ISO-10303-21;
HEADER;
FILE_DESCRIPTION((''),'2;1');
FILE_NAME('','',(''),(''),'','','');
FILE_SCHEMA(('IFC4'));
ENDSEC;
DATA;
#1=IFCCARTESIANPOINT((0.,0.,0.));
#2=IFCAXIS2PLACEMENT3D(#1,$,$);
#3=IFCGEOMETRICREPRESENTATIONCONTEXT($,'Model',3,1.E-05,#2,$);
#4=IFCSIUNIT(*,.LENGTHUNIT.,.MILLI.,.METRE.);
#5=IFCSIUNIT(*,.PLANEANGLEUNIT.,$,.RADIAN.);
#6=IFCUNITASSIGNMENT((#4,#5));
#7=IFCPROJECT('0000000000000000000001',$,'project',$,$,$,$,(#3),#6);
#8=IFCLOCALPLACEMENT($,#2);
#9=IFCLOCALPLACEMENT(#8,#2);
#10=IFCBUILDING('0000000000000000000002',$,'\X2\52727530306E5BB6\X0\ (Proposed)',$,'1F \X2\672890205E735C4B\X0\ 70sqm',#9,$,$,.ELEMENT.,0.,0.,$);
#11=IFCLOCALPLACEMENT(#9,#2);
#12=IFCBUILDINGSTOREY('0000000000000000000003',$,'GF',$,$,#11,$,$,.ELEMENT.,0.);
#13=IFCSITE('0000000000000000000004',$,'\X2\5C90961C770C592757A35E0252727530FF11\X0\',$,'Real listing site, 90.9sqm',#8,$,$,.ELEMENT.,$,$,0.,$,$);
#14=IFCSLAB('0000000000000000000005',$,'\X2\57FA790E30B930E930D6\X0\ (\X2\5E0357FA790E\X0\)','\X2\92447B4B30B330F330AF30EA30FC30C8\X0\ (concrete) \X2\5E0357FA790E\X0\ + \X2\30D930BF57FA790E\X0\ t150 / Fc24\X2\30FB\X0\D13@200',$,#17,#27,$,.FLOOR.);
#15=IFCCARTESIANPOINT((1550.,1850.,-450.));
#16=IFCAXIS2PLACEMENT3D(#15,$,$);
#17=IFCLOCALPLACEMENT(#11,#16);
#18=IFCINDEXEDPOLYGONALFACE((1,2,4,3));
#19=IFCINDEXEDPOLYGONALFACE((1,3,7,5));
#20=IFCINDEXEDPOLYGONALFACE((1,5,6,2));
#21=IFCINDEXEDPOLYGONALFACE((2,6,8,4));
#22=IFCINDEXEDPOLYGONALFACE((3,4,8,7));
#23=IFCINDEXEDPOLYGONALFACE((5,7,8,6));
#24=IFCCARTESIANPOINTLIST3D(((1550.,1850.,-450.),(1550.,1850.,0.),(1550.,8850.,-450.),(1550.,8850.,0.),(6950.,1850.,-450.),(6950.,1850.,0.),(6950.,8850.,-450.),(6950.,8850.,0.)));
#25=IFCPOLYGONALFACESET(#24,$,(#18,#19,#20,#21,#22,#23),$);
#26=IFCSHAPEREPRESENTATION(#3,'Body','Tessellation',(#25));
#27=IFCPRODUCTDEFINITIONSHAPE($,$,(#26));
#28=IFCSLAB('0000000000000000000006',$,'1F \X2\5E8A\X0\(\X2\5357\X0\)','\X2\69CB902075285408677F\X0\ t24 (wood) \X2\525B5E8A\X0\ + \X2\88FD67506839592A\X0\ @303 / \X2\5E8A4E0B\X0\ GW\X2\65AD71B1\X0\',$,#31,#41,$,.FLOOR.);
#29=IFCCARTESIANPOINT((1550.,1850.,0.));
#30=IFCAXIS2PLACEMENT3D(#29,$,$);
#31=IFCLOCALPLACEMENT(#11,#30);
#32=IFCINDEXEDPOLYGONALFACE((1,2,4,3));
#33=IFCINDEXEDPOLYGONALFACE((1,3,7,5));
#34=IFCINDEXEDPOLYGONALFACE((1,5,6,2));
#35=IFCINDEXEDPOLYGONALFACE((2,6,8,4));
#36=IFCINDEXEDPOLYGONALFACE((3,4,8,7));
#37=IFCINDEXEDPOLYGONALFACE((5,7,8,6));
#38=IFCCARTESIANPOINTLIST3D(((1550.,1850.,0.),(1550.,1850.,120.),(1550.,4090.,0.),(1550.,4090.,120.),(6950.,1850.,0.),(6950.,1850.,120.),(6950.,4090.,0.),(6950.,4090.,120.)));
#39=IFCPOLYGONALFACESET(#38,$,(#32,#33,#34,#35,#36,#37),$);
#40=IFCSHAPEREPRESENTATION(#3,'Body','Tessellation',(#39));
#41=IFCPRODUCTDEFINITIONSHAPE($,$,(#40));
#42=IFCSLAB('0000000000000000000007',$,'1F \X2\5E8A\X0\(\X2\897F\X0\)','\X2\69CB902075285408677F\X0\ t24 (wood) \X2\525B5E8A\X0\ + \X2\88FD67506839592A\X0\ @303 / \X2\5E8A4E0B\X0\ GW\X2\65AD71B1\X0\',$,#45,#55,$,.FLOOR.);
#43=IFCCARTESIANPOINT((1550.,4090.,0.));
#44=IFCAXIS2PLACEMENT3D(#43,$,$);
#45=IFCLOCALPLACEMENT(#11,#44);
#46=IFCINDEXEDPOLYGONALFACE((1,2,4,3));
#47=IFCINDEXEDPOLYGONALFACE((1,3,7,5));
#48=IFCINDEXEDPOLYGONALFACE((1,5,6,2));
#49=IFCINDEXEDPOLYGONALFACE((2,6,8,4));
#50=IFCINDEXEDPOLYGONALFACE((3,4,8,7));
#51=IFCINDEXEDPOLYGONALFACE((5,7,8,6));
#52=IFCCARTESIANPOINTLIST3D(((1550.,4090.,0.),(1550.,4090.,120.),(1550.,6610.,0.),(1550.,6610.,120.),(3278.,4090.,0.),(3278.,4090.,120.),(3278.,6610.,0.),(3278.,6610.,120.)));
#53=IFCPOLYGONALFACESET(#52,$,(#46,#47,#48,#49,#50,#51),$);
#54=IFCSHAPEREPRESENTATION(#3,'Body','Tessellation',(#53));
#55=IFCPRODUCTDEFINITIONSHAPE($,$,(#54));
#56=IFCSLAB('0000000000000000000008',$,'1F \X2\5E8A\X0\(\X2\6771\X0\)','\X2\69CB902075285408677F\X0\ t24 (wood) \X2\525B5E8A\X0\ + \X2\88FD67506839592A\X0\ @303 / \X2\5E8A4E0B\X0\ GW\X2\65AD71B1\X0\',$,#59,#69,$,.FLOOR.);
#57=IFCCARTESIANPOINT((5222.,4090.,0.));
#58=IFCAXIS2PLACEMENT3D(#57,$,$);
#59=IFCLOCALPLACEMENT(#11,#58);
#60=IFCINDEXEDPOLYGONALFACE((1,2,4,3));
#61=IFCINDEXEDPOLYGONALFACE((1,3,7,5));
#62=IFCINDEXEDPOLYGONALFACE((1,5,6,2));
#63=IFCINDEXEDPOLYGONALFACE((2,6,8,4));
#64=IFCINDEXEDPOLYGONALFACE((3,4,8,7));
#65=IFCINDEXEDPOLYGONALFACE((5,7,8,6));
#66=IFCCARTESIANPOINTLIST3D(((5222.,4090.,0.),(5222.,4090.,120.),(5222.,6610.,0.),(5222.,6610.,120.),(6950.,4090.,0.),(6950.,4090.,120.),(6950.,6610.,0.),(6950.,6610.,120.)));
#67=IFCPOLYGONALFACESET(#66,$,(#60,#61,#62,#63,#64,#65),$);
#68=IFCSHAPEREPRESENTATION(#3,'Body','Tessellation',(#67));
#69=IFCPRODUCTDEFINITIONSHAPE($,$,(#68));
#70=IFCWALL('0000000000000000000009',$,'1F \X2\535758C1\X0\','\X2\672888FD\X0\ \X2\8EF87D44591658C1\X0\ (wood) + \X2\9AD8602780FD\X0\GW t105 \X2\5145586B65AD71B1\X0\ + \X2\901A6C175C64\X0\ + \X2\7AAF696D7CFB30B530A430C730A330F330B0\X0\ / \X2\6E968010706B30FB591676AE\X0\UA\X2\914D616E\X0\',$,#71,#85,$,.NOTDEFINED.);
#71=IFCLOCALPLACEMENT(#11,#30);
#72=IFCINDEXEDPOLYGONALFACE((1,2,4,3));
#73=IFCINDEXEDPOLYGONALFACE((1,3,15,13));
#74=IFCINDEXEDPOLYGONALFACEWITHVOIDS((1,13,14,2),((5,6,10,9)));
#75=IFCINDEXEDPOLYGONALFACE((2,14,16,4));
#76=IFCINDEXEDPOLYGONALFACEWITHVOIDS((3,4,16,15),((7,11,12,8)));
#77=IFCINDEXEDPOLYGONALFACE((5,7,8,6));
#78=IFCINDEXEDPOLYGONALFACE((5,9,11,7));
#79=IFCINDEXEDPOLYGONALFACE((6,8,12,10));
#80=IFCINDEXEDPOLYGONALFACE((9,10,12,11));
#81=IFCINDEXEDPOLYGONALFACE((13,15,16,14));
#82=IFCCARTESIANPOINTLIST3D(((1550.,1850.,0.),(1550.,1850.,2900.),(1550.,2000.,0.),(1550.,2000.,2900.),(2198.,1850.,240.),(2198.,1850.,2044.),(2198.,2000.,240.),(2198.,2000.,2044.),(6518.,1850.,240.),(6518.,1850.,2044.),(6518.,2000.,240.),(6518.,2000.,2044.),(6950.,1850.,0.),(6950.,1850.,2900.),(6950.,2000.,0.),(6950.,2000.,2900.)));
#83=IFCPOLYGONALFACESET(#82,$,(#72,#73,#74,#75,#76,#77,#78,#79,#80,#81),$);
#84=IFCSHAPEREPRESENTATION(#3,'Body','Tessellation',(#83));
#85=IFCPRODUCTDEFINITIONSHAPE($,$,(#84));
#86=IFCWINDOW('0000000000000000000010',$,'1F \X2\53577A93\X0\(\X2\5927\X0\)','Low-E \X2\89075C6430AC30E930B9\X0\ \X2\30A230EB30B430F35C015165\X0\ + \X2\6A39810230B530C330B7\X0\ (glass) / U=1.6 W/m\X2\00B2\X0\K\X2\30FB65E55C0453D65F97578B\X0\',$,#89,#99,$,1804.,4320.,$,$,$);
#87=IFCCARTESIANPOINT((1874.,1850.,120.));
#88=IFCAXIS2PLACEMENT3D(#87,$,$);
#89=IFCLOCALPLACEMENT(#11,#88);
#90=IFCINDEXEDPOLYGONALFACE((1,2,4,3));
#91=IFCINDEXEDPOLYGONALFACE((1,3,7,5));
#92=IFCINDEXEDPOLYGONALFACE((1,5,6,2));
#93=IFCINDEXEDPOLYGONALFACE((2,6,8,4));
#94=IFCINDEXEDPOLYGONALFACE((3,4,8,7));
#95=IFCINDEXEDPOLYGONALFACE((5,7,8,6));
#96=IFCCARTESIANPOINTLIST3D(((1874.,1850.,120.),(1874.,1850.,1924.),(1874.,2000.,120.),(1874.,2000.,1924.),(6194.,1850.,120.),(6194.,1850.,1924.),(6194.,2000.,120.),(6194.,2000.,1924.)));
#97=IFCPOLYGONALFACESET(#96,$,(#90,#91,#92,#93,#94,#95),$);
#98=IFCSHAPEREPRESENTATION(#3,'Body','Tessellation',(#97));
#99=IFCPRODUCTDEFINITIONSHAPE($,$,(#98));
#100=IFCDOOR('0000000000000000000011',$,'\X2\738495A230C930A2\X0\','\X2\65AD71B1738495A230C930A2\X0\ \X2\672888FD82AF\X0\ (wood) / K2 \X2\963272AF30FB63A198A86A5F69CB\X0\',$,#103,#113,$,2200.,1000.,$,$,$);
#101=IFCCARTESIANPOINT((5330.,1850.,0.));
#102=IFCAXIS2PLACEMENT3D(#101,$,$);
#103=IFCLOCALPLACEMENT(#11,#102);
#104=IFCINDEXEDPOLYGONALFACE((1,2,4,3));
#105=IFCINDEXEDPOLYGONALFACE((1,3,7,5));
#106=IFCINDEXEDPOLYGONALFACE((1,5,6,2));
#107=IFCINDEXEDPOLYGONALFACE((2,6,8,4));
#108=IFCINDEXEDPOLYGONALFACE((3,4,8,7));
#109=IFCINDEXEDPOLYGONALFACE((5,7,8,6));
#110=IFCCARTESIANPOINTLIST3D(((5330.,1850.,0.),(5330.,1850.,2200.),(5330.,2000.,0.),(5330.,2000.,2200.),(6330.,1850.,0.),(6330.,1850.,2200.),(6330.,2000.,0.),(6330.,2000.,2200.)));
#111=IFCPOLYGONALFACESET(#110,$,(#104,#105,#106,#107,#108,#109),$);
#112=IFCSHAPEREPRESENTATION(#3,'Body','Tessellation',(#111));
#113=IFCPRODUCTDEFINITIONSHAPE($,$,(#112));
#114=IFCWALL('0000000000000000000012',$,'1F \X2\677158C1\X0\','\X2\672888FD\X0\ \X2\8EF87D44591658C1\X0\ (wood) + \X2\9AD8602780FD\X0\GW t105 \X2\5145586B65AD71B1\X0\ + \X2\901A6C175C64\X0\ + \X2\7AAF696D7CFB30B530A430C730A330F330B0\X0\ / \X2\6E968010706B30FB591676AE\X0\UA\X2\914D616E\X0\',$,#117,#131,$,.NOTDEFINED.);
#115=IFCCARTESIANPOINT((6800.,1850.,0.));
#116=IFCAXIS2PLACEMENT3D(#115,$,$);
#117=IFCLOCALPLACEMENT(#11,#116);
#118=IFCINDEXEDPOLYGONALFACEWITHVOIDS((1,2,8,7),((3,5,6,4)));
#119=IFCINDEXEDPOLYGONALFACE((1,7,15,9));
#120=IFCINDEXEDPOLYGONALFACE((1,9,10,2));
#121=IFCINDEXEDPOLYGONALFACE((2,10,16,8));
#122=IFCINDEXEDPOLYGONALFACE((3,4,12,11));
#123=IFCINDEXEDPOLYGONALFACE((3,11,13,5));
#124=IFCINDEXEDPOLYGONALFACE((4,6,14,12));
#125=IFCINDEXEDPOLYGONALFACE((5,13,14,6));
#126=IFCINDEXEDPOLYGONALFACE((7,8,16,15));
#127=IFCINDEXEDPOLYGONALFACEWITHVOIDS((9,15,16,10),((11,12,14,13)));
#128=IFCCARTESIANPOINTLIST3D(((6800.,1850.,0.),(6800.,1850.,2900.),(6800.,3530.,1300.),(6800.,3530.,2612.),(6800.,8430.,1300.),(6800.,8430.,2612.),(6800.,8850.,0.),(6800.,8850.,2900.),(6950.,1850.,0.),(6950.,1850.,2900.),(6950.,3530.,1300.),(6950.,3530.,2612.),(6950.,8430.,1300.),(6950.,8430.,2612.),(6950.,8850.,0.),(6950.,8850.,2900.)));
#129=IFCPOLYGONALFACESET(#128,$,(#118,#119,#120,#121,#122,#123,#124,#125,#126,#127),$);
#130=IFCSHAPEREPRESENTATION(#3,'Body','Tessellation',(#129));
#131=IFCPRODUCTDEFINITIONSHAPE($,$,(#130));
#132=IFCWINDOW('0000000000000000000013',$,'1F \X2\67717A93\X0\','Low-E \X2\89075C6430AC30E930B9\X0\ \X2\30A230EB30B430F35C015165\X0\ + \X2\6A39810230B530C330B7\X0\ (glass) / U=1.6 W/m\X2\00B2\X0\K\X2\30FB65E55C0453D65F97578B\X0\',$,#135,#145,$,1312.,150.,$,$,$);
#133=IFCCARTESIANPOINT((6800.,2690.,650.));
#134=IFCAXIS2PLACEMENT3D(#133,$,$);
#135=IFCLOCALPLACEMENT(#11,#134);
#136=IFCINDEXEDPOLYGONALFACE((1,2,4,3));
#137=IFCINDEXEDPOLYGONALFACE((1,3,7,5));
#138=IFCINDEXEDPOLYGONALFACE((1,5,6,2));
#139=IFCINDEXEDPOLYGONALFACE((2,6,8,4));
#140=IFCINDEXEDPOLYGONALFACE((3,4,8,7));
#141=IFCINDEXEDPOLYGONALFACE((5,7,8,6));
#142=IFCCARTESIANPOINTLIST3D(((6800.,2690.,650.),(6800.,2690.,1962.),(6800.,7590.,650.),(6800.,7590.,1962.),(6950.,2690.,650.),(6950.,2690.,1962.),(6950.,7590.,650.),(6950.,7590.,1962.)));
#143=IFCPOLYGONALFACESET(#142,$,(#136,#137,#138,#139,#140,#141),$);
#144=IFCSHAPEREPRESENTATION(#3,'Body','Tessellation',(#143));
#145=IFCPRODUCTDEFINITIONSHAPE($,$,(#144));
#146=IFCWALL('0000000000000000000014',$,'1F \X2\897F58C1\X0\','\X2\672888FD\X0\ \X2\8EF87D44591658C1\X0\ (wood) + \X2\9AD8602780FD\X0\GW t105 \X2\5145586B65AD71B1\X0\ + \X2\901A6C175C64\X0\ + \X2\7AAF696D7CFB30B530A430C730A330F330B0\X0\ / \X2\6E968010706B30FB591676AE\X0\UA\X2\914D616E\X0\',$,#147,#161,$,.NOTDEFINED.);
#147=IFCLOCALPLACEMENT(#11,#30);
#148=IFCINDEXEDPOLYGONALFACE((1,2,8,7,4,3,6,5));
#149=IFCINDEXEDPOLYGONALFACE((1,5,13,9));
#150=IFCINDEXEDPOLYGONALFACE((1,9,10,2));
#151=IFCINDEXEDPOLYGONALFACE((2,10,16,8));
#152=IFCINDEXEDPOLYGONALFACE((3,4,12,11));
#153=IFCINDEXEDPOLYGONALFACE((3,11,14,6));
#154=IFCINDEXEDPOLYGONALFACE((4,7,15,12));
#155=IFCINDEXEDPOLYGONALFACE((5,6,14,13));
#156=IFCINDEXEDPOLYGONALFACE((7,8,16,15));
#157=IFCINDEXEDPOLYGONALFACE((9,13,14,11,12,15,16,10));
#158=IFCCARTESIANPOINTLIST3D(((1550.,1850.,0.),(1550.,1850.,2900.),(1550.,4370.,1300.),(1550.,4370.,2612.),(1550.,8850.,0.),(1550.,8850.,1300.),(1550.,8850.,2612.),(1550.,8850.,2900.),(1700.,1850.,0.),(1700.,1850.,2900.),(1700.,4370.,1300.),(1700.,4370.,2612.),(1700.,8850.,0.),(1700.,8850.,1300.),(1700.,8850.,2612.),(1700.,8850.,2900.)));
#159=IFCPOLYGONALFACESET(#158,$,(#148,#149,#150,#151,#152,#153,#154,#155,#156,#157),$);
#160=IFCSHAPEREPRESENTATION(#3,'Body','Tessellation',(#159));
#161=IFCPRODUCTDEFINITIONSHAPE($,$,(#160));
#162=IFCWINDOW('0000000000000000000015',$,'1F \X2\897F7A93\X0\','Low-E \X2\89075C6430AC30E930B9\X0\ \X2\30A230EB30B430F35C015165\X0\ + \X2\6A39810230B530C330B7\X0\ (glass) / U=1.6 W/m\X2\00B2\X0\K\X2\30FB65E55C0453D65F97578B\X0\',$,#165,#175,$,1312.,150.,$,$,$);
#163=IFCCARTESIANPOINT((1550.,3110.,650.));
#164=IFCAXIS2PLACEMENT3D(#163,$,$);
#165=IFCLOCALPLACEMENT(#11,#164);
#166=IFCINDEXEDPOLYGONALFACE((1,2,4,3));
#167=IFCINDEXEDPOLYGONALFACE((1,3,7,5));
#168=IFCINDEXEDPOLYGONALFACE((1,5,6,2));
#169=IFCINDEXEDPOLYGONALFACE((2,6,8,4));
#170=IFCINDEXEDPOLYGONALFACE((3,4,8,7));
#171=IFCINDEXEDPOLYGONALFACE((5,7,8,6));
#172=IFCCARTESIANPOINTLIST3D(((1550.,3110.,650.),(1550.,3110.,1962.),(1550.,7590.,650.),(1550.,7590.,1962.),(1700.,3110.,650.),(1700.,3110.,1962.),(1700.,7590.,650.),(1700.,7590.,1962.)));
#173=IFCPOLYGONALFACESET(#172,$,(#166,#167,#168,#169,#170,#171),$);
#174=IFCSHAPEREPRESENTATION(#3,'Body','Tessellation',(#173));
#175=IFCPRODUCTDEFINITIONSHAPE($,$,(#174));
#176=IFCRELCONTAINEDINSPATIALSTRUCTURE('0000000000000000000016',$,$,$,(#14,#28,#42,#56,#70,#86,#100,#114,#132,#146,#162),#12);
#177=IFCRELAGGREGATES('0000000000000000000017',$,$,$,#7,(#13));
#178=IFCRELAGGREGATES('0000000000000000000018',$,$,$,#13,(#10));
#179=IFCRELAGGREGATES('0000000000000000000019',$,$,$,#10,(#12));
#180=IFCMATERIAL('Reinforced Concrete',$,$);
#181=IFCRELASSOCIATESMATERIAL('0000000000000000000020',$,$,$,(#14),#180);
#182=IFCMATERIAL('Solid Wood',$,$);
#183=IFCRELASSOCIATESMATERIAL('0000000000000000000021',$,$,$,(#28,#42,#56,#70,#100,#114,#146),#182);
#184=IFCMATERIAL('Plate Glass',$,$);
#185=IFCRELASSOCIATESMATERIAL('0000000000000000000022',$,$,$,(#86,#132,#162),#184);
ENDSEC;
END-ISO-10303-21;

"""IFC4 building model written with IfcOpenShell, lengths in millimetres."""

from ifc_helpers import new_model, si_unit, frame, frame_2d, origin, place, context, project, spatial, rectangle, extrude, material, element, fill, save


model = new_model("IFC4")

# Units and contexts
model_context = context("Model", 3, precision=1e-05, world=origin())
ifc_project = project(units=[si_unit("LENGTHUNIT", "METRE", prefix="MILLI"), si_unit("PLANEANGLEUNIT", "RADIAN")], contexts=[model_context])

# Site, building, storey
site_placement = place(None, origin())
site = spatial("IfcSite", under=ifc_project, at=site_placement, Name="岐阜県大垣市割田１", ObjectType="Real listing site, 90.9sqm", CompositionType="ELEMENT", RefElevation=0.0)
building_placement = place(site_placement, origin())
building = spatial("IfcBuilding", under=site, at=building_placement, Name="割田の家 (Proposed)", ObjectType="1F 木造平屋 70sqm", CompositionType="ELEMENT", ElevationOfRefHeight=0.0, ElevationOfTerrain=0.0)
storey_placement = place(building_placement, origin())
storey = spatial("IfcBuildingStorey", under=building, at=storey_placement, Name="GF", CompositionType="ELEMENT", Elevation=0.0)

# Slabs
ifc_material_1 = material(Name="Reinforced Concrete")
slab_1_placement = place(storey_placement, frame((1550.0, 1850.0, -450.0)))
element("IfcSlab", 1, at=slab_1_placement, inside=storey, material=ifc_material_1, Name="基礎スラブ (布基礎)", Description="鉄筋コンクリート (concrete) 布基礎 + ベタ基礎 t150 / Fc24・D13@200", PredefinedType="FLOOR", context=model_context, shape_type="SweptSolid", body=[
    extrude(rectangle(XDim=5400.0, YDim=7000.0, at=frame_2d((2700.0, 3500.0))), frame((1550.0, 1850.0, -450.0)), (0.0, 0.0, 1.0), 450.0),
])
ifc_material_2 = material(Name="Solid Wood")
slab_2_placement = place(storey_placement, frame((1550.0, 1850.0, 0.0)))
element("IfcSlab", 2, at=slab_2_placement, inside=storey, material=ifc_material_2, Name="1F 床(南)", Description="構造用合板 t24 (wood) 剛床 + 製材根太 @303 / 床下 GW断熱", PredefinedType="FLOOR", context=model_context, shape_type="SweptSolid", body=[
    extrude(rectangle(XDim=5400.0, YDim=2240.0, at=frame_2d((2700.0, 1120.0))), frame((1550.0, 1850.0, 0.0)), (0.0, 0.0, 1.0), 120.0),
])
slab_3_placement = place(storey_placement, frame((1550.0, 4090.0, 0.0)))
element("IfcSlab", 3, at=slab_3_placement, inside=storey, material=ifc_material_2, Name="1F 床(西)", Description="構造用合板 t24 (wood) 剛床 + 製材根太 @303 / 床下 GW断熱", PredefinedType="FLOOR", context=model_context, shape_type="SweptSolid", body=[
    extrude(rectangle(XDim=1728.0, YDim=2520.0, at=frame_2d((864.0, 1260.0))), frame((1550.0, 4090.0, 0.0)), (0.0, 0.0, 1.0), 120.0),
])
slab_4_placement = place(storey_placement, frame((5222.0, 4090.0, 0.0)))
element("IfcSlab", 4, at=slab_4_placement, inside=storey, material=ifc_material_2, Name="1F 床(東)", Description="構造用合板 t24 (wood) 剛床 + 製材根太 @303 / 床下 GW断熱", PredefinedType="FLOOR", context=model_context, shape_type="SweptSolid", body=[
    extrude(rectangle(XDim=1728.0, YDim=2520.0, at=frame_2d((864.0, 1260.0))), frame((5222.0, 4090.0, 0.0)), (0.0, 0.0, 1.0), 120.0),
])

# Wall, openings, window, door
wall_1_placement = place(storey_placement, frame((1550.0, 1850.0, 0.0)))
wall_1 = element("IfcWall", 5, at=wall_1_placement, inside=storey, material=ifc_material_2, Name="1F 南壁", Description="木製 軸組外壁 (wood) + 高性能GW t105 充填断熱 + 通気層 + 窯業系サイディング / 準耐火・外皮UA配慮", PredefinedType="NOTDEFINED", context=model_context, shape_type="SweptSolid", body=[
    extrude(rectangle(XDim=5400.0, YDim=150.0, at=frame_2d((2700.0, 75.0))), frame((1550.0, 1850.0, 0.0)), (0.0, 0.0, 1.0), 2900.0),
])
opening_1_placement = place(storey_placement, frame((1874.0, 1850.0, 120.0)))
opening_1 = element("IfcOpeningElement", 6, at=opening_1_placement, cuts=wall_1, PredefinedType="NOTDEFINED", context=model_context, shape_type="SweptSolid", body=[
    extrude(rectangle(XDim=4320.0, YDim=150.0, at=frame_2d((2160.0, 75.0))), frame((1874.0, 1850.0, 120.0)), (0.0, 0.0, 1.0), 1804.0),
])
opening_2_placement = place(storey_placement, frame((5330.0, 1850.0, 0.0)))
opening_2 = element("IfcOpeningElement", 7, at=opening_2_placement, cuts=wall_1, PredefinedType="NOTDEFINED", context=model_context, shape_type="SweptSolid", body=[
    extrude(rectangle(XDim=1000.0, YDim=150.0, at=frame_2d((500.0, 75.0))), frame((5330.0, 1850.0, 0.0)), (0.0, 0.0, 1.0), 2200.0),
])
ifc_material_3 = material(Name="Plate Glass")
window_1_placement = place(storey_placement, frame((1874.0, 1850.0, 120.0)))
window_1 = element("IfcWindow", 8, at=window_1_placement, inside=storey, material=ifc_material_3, Name="1F 南窓(大)", Description="Low-E 複層ガラス アルゴン封入 + 樹脂サッシ (glass) / U=1.6 W/m²K・日射取得型", OverallHeight=1804.0, OverallWidth=4320.0, context=model_context, shape_type="SweptSolid", body=[
    extrude(rectangle(XDim=4320.0, YDim=150.0, at=frame_2d((2160.0, 75.0))), frame((1874.0, 1850.0, 120.0)), (0.0, 0.0, 1.0), 1804.0),
])
fill(opening_1, window_1)
door_placement = place(storey_placement, frame((5330.0, 1850.0, 0.0)))
door = element("IfcDoor", 9, at=door_placement, inside=storey, material=ifc_material_2, Name="玄関ドア", Description="断熱玄関ドア 木製芯 (wood) / K2 防犯・採風機構", OverallHeight=2200.0, OverallWidth=1000.0, context=model_context, shape_type="SweptSolid", body=[
    extrude(rectangle(XDim=1000.0, YDim=150.0, at=frame_2d((500.0, 75.0))), frame((5330.0, 1850.0, 0.0)), (0.0, 0.0, 1.0), 2200.0),
])
fill(opening_2, door)

# Walls, openings, windows
wall_2_placement = place(storey_placement, frame((6800.0, 1850.0, 0.0)))
wall_2 = element("IfcWall", 10, at=wall_2_placement, inside=storey, material=ifc_material_2, Name="1F 東壁", Description="木製 軸組外壁 (wood) + 高性能GW t105 充填断熱 + 通気層 + 窯業系サイディング / 準耐火・外皮UA配慮", PredefinedType="NOTDEFINED", context=model_context, shape_type="SweptSolid", body=[
    extrude(rectangle(XDim=150.0, YDim=7000.0, at=frame_2d((75.0, 3500.0))), frame((6800.0, 1850.0, 0.0)), (0.0, 0.0, 1.0), 2900.0),
])
opening_3_placement = place(storey_placement, frame((6800.0, 2690.0, 650.0)))
opening_3 = element("IfcOpeningElement", 11, at=opening_3_placement, cuts=wall_2, PredefinedType="NOTDEFINED", context=model_context, shape_type="SweptSolid", body=[
    extrude(rectangle(XDim=150.0, YDim=4900.0, at=frame_2d((75.0, 2450.0))), frame((6800.0, 2690.0, 650.0)), (0.0, 0.0, 1.0), 1312.0),
])
window_2_placement = place(storey_placement, frame((6800.0, 2690.0, 650.0)))
window_2 = element("IfcWindow", 12, at=window_2_placement, inside=storey, material=ifc_material_3, Name="1F 東窓", Description="Low-E 複層ガラス アルゴン封入 + 樹脂サッシ (glass) / U=1.6 W/m²K・日射取得型", OverallHeight=1312.0, OverallWidth=150.0, context=model_context, shape_type="SweptSolid", body=[
    extrude(rectangle(XDim=150.0, YDim=4900.0, at=frame_2d((75.0, 2450.0))), frame((6800.0, 2690.0, 650.0)), (0.0, 0.0, 1.0), 1312.0),
])
fill(opening_3, window_2)
wall_3_placement = place(storey_placement, frame((1550.0, 1850.0, 0.0)))
wall_3 = element("IfcWall", 13, at=wall_3_placement, inside=storey, material=ifc_material_2, Name="1F 西壁", Description="木製 軸組外壁 (wood) + 高性能GW t105 充填断熱 + 通気層 + 窯業系サイディング / 準耐火・外皮UA配慮", PredefinedType="NOTDEFINED", context=model_context, shape_type="SweptSolid", body=[
    extrude(rectangle(XDim=150.0, YDim=7000.0, at=frame_2d((75.0, 3500.0))), frame((1550.0, 1850.0, 0.0)), (0.0, 0.0, 1.0), 2900.0),
])
opening_4_placement = place(storey_placement, frame((1550.0, 3110.0, 650.0)))
opening_4 = element("IfcOpeningElement", 14, at=opening_4_placement, cuts=wall_3, PredefinedType="NOTDEFINED", context=model_context, shape_type="SweptSolid", body=[
    extrude(rectangle(XDim=150.0, YDim=4480.0, at=frame_2d((75.0, 2240.0))), frame((1550.0, 3110.0, 650.0)), (0.0, 0.0, 1.0), 1312.0),
])
window_3_placement = place(storey_placement, frame((1550.0, 3110.0, 650.0)))
window_3 = element("IfcWindow", 15, at=window_3_placement, inside=storey, material=ifc_material_3, Name="1F 西窓", Description="Low-E 複層ガラス アルゴン封入 + 樹脂サッシ (glass) / U=1.6 W/m²K・日射取得型", OverallHeight=1312.0, OverallWidth=150.0, context=model_context, shape_type="SweptSolid", body=[
    extrude(rectangle(XDim=150.0, YDim=4480.0, at=frame_2d((75.0, 2240.0))), frame((1550.0, 3110.0, 650.0)), (0.0, 0.0, 1.0), 1312.0),
])
fill(opening_4, window_3)

save(model, "model.ifc")
